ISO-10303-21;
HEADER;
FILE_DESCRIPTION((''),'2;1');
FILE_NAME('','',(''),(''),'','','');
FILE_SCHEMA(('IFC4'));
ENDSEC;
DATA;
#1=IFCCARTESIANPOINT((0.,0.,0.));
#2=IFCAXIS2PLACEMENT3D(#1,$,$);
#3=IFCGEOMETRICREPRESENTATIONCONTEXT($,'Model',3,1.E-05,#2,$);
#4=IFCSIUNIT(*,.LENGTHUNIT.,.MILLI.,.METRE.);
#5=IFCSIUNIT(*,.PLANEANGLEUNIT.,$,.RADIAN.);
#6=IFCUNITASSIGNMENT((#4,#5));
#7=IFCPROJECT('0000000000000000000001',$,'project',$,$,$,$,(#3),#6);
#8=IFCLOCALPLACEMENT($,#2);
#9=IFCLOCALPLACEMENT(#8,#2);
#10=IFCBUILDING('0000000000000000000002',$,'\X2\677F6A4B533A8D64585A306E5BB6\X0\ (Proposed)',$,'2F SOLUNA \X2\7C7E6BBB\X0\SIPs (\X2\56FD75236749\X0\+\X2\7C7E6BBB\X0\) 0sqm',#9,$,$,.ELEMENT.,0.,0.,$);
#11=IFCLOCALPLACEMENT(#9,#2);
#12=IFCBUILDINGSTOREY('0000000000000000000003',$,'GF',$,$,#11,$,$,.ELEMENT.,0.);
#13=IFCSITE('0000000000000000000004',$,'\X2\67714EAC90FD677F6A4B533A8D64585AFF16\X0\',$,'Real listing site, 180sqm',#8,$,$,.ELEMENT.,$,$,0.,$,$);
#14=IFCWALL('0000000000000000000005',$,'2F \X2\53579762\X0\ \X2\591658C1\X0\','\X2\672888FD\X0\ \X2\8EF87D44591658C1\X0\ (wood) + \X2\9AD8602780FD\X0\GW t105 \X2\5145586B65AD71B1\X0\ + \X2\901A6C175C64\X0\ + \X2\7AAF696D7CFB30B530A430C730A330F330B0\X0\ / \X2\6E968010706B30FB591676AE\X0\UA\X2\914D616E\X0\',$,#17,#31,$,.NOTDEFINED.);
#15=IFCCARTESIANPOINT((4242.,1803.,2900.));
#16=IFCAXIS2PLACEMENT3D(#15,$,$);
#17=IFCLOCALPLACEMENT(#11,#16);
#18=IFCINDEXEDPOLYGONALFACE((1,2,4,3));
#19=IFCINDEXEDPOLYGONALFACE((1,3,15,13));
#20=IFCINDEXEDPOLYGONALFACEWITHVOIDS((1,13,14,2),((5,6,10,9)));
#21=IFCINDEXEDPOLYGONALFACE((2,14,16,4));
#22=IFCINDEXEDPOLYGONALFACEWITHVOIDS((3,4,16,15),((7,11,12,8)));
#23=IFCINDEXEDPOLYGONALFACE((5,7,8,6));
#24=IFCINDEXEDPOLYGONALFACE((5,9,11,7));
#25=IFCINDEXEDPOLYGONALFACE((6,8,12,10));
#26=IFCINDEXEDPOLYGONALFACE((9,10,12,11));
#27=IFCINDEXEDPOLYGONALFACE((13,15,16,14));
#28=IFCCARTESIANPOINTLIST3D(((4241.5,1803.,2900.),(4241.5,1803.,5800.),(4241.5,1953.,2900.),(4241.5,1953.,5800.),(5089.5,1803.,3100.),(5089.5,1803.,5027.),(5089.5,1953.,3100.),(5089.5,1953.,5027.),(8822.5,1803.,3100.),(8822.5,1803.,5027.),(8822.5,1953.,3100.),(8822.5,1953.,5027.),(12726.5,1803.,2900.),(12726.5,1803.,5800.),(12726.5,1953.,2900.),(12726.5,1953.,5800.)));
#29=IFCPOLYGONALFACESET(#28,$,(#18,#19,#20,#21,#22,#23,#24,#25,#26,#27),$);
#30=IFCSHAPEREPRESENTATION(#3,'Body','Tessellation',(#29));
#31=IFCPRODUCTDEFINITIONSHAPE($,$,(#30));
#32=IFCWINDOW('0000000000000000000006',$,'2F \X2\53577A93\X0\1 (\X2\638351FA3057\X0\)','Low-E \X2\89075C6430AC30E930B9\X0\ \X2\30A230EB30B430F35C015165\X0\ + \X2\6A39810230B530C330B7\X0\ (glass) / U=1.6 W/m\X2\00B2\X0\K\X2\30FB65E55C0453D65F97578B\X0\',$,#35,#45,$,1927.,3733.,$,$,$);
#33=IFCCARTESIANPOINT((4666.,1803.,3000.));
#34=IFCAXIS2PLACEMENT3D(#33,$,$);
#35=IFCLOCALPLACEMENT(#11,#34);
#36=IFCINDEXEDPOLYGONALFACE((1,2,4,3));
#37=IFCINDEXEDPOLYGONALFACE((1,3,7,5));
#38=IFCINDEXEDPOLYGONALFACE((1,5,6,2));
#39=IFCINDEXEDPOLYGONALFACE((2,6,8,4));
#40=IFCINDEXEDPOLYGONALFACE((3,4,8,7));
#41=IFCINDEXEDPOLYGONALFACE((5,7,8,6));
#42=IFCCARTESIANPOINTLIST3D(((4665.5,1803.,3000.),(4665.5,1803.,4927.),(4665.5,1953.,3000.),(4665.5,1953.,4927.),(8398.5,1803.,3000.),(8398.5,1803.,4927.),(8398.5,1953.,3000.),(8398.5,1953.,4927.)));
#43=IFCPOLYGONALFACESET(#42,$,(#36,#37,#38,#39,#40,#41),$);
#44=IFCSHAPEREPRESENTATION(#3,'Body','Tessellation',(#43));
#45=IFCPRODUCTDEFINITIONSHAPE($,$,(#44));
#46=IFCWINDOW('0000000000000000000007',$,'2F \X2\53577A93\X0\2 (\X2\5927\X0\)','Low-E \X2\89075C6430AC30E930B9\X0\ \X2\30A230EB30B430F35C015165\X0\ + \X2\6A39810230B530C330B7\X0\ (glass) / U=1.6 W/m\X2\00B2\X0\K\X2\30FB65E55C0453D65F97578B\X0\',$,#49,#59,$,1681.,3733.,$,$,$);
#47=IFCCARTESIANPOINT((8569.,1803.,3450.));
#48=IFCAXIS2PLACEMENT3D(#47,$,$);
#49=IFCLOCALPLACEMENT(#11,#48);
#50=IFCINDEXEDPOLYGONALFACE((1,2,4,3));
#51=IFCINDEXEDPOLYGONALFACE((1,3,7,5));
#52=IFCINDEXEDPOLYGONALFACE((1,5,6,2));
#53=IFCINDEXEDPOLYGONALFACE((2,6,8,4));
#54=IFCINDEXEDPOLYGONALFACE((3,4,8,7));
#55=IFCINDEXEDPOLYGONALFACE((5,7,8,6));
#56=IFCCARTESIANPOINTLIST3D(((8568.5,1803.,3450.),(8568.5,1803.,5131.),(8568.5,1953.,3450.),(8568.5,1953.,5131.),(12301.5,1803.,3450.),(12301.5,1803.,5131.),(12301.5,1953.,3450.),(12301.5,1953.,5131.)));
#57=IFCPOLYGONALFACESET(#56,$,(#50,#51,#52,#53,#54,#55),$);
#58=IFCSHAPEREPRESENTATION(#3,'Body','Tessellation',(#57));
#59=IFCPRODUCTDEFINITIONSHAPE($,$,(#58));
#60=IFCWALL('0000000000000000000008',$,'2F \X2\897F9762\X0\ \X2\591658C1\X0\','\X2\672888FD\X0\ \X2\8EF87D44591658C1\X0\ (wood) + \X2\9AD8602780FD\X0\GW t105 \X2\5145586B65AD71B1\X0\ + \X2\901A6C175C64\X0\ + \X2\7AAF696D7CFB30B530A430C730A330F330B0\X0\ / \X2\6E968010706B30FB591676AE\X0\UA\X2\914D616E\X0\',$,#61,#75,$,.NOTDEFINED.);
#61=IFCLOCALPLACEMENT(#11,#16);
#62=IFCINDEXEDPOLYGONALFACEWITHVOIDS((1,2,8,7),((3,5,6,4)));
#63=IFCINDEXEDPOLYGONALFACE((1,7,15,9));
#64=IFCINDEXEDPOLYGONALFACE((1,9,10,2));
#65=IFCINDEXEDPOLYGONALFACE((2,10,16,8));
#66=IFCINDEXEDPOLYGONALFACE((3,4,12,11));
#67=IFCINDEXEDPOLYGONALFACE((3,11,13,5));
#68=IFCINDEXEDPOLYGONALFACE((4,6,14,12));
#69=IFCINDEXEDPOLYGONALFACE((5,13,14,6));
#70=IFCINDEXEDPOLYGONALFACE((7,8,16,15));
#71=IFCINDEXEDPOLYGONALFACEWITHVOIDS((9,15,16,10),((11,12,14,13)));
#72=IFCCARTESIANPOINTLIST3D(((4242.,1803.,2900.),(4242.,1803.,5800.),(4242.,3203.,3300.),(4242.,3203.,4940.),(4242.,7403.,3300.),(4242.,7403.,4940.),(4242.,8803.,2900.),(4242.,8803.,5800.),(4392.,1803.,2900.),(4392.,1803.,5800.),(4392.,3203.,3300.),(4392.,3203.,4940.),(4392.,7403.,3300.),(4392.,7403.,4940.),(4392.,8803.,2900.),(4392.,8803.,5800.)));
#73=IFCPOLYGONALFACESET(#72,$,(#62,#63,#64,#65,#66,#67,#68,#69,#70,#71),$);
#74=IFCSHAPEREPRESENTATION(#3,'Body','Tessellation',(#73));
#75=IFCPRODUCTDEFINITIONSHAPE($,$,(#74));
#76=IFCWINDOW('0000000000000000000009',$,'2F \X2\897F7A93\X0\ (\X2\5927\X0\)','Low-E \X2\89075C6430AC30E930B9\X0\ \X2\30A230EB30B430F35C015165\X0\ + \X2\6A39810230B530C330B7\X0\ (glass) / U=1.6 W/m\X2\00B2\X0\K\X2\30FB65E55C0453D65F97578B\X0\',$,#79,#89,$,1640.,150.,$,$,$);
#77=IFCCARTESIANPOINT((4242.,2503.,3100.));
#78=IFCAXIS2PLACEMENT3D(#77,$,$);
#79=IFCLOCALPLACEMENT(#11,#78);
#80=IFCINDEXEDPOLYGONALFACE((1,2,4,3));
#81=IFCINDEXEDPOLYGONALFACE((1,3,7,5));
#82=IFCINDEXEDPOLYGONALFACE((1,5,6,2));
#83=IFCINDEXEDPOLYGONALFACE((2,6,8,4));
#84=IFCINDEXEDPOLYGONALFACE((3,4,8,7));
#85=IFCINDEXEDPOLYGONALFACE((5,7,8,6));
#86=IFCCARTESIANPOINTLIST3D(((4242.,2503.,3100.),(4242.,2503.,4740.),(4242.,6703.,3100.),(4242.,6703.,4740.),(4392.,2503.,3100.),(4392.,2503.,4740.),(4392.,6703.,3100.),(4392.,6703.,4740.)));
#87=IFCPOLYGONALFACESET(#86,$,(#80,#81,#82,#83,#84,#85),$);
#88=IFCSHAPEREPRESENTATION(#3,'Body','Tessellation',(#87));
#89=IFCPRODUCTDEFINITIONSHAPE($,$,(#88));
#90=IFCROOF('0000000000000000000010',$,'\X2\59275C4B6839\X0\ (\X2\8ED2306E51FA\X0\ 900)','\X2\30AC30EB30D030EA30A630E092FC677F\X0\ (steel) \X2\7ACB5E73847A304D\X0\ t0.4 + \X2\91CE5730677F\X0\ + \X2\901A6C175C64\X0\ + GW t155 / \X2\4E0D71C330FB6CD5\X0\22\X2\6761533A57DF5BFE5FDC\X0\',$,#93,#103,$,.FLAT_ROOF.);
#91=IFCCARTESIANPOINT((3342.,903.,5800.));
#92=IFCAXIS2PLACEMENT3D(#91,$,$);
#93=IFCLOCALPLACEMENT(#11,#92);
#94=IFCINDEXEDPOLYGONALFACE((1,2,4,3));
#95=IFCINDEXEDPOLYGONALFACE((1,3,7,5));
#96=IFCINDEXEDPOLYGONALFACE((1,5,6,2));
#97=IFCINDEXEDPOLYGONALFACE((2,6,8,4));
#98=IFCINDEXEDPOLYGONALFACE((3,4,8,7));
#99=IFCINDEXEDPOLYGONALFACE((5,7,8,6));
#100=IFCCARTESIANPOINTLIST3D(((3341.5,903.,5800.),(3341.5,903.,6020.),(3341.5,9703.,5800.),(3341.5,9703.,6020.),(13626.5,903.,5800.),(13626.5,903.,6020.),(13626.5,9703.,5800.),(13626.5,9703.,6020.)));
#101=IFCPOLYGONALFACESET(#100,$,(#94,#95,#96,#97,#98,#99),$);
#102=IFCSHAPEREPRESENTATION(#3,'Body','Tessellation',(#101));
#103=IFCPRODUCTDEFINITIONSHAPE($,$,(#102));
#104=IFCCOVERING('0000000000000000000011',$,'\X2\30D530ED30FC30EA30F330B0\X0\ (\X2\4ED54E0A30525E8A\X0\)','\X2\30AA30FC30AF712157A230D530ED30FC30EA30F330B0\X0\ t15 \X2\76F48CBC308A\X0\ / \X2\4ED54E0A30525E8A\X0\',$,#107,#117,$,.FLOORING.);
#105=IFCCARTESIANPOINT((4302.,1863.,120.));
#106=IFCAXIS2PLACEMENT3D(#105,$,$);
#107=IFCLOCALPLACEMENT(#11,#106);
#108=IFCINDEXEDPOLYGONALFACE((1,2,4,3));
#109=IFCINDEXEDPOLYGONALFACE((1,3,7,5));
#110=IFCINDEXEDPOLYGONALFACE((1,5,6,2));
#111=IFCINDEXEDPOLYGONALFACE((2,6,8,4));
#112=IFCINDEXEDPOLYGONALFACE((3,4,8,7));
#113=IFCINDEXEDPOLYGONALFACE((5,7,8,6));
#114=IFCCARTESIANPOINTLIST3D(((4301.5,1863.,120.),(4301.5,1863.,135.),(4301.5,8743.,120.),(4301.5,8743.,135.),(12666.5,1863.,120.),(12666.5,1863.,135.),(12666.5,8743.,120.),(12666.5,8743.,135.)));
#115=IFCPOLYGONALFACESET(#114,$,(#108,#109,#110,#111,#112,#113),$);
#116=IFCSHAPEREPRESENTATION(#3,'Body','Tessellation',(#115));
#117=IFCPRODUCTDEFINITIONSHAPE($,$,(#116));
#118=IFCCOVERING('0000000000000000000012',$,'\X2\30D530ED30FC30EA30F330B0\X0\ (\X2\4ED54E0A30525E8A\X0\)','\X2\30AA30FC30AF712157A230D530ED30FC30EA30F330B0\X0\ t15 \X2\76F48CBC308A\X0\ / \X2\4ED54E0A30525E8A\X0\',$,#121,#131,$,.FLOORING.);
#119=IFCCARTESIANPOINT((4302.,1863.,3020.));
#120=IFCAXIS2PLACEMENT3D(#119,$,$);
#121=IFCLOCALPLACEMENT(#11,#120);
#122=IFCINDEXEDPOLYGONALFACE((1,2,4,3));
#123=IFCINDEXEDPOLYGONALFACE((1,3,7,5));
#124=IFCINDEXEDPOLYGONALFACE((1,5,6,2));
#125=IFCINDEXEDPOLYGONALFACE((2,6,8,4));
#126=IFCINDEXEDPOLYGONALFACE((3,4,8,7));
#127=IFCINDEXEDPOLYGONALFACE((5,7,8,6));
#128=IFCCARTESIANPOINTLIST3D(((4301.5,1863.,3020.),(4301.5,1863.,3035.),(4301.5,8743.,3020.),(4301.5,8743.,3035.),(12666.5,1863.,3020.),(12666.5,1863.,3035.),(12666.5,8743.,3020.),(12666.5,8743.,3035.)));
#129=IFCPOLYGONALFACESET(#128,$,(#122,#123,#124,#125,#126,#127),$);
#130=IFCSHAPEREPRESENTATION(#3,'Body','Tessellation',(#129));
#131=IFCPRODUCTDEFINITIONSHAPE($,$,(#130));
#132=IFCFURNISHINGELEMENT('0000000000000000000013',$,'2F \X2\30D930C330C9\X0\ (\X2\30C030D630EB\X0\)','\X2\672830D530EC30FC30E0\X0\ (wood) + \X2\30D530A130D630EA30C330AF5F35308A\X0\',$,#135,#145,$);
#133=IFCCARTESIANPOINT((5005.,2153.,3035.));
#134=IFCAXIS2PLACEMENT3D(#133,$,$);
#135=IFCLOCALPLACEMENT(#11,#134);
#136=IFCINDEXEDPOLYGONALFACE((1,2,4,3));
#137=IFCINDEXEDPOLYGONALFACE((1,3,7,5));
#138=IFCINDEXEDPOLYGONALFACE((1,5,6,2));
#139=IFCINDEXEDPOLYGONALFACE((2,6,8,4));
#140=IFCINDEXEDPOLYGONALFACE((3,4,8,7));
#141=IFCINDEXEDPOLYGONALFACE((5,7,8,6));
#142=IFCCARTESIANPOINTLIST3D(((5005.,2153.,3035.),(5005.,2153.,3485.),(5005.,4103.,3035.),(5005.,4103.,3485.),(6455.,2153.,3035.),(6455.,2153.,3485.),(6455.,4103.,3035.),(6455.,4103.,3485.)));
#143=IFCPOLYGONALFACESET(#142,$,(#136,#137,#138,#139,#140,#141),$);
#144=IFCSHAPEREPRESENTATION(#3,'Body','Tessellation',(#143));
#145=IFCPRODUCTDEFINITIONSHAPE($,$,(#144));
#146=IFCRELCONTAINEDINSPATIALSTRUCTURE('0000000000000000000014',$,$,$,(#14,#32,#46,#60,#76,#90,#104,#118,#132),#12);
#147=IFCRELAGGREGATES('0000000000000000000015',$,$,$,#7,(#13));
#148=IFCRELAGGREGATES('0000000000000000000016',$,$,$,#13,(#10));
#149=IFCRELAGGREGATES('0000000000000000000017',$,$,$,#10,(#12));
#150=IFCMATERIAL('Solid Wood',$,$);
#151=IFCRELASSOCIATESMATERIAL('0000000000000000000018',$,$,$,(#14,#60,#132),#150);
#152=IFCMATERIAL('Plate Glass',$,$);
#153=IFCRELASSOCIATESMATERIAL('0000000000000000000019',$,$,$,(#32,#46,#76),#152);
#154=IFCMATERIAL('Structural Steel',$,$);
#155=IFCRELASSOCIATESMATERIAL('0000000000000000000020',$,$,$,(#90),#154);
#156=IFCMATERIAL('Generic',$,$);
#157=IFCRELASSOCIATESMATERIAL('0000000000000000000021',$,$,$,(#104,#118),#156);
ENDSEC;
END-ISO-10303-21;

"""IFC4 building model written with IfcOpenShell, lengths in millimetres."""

from ifc_helpers import new_model, si_unit, frame, frame_2d, origin, place, context, project, spatial, rectangle, extrude, material, element, fill, save


model = new_model("IFC4")

# Units and contexts
model_context = context("Model", 3, precision=1e-05, world=origin())
ifc_project = project(units=[si_unit("LENGTHUNIT", "METRE", prefix="MILLI"), si_unit("PLANEANGLEUNIT", "RADIAN")], contexts=[model_context])

# Site, building, storey
site_placement = place(None, origin())
site = spatial("IfcSite", under=ifc_project, at=site_placement, Name="東京都板橋区赤塚６", ObjectType="Real listing site, 180sqm", CompositionType="ELEMENT", RefElevation=0.0)
building_placement = place(site_placement, origin())
building = spatial("IfcBuilding", under=site, at=building_placement, Name="板橋区赤塚の家 (Proposed)", ObjectType="2F SOLUNA 籾殻SIPs (国産杉+籾殻) 0sqm", CompositionType="ELEMENT", ElevationOfRefHeight=0.0, ElevationOfTerrain=0.0)
storey_placement = place(building_placement, origin())
storey = spatial("IfcBuildingStorey", under=building, at=storey_placement, Name="GF", CompositionType="ELEMENT", Elevation=0.0)

# Shared definitions
ifc_material_1 = material(Name="Solid Wood")

# Shared definitions
ifc_material_2 = material(Name="Plate Glass")

# Wall, openings, windows
wall_1_placement = place(storey_placement, frame((4242.0, 1803.0, 2900.0)))
wall_1 = element("IfcWall", 1, at=wall_1_placement, inside=storey, material=ifc_material_1, Name="2F 南面 外壁", Description="木製 軸組外壁 (wood) + 高性能GW t105 充填断熱 + 通気層 + 窯業系サイディング / 準耐火・外皮UA配慮", PredefinedType="NOTDEFINED", context=model_context, shape_type="SweptSolid", body=[
    extrude(rectangle(XDim=8485.0, YDim=150.0, at=frame_2d((4242.0, 75.0))), frame((4242.0, 1803.0, 2900.0)), (0.0, 0.0, 1.0), 2900.0),
])
opening_1_placement = place(storey_placement, frame((4666.0, 1803.0, 3000.0)))
opening_1 = element("IfcOpeningElement", 2, at=opening_1_placement, cuts=wall_1, PredefinedType="NOTDEFINED", context=model_context, shape_type="SweptSolid", body=[
    extrude(rectangle(XDim=3733.0, YDim=150.0, at=frame_2d((1866.0, 75.0))), frame((4666.0, 1803.0, 3000.0)), (0.0, 0.0, 1.0), 1927.0),
])
opening_2_placement = place(storey_placement, frame((8569.0, 1803.0, 3450.0)))
opening_2 = element("IfcOpeningElement", 3, at=opening_2_placement, cuts=wall_1, PredefinedType="NOTDEFINED", context=model_context, shape_type="SweptSolid", body=[
    extrude(rectangle(XDim=3733.0, YDim=150.0, at=frame_2d((1866.0, 75.0))), frame((8569.0, 1803.0, 3450.0)), (0.0, 0.0, 1.0), 1681.0),
])
window_1_placement = place(storey_placement, frame((4666.0, 1803.0, 3000.0)))
window_1 = element("IfcWindow", 4, at=window_1_placement, inside=storey, material=ifc_material_2, Name="2F 南窓1 (掃出し)", Description="Low-E 複層ガラス アルゴン封入 + 樹脂サッシ (glass) / U=1.6 W/m²K・日射取得型", OverallHeight=1927.0, OverallWidth=3733.0, context=model_context, shape_type="SweptSolid", body=[
    extrude(rectangle(XDim=3733.0, YDim=150.0, at=frame_2d((1866.0, 75.0))), frame((4666.0, 1803.0, 3000.0)), (0.0, 0.0, 1.0), 1927.0),
])
fill(opening_1, window_1)
window_2_placement = place(storey_placement, frame((8569.0, 1803.0, 3450.0)))
window_2 = element("IfcWindow", 5, at=window_2_placement, inside=storey, material=ifc_material_2, Name="2F 南窓2 (大)", Description="Low-E 複層ガラス アルゴン封入 + 樹脂サッシ (glass) / U=1.6 W/m²K・日射取得型", OverallHeight=1681.0, OverallWidth=3733.0, context=model_context, shape_type="SweptSolid", body=[
    extrude(rectangle(XDim=3733.0, YDim=150.0, at=frame_2d((1866.0, 75.0))), frame((8569.0, 1803.0, 3450.0)), (0.0, 0.0, 1.0), 1681.0),
])
fill(opening_2, window_2)

# Wall, opening, window
wall_2_placement = place(storey_placement, frame((4242.0, 1803.0, 2900.0)))
wall_2 = element("IfcWall", 6, at=wall_2_placement, inside=storey, material=ifc_material_1, Name="2F 西面 外壁", Description="木製 軸組外壁 (wood) + 高性能GW t105 充填断熱 + 通気層 + 窯業系サイディング / 準耐火・外皮UA配慮", PredefinedType="NOTDEFINED", context=model_context, shape_type="SweptSolid", body=[
    extrude(rectangle(XDim=150.0, YDim=7000.0, at=frame_2d((75.0, 3500.0))), frame((4242.0, 1803.0, 2900.0)), (0.0, 0.0, 1.0), 2900.0),
])
opening_3_placement = place(storey_placement, frame((4242.0, 2503.0, 3100.0)))
opening_3 = element("IfcOpeningElement", 7, at=opening_3_placement, cuts=wall_2, PredefinedType="NOTDEFINED", context=model_context, shape_type="SweptSolid", body=[
    extrude(rectangle(XDim=150.0, YDim=4200.0, at=frame_2d((75.0, 2100.0))), frame((4242.0, 2503.0, 3100.0)), (0.0, 0.0, 1.0), 1640.0),
])
window_3_placement = place(storey_placement, frame((4242.0, 2503.0, 3100.0)))
window_3 = element("IfcWindow", 8, at=window_3_placement, inside=storey, material=ifc_material_2, Name="2F 西窓 (大)", Description="Low-E 複層ガラス アルゴン封入 + 樹脂サッシ (glass) / U=1.6 W/m²K・日射取得型", OverallHeight=1640.0, OverallWidth=150.0, context=model_context, shape_type="SweptSolid", body=[
    extrude(rectangle(XDim=150.0, YDim=4200.0, at=frame_2d((75.0, 2100.0))), frame((4242.0, 2503.0, 3100.0)), (0.0, 0.0, 1.0), 1640.0),
])
fill(opening_3, window_3)

# Roof
ifc_material_3 = material(Name="Structural Steel")
roof_placement = place(storey_placement, frame((3342.0, 903.0, 5800.0)))
element("IfcRoof", 9, at=roof_placement, inside=storey, material=ifc_material_3, Name="大屋根 (軒の出 900)", Description="ガルバリウム鋼板 (steel) 立平葺き t0.4 + 野地板 + 通気層 + GW t155 / 不燃・法22条区域対応", PredefinedType="FLAT_ROOF", context=model_context, shape_type="SweptSolid", body=[
    extrude(rectangle(XDim=10285.0, YDim=8800.0, at=frame_2d((5142.0, 4400.0))), frame((3342.0, 903.0, 5800.0)), (0.0, 0.0, 1.0), 220.0),
])

# Coverings
ifc_material_4 = material(Name="Generic")
covering_1_placement = place(storey_placement, frame((4302.0, 1863.0, 120.0)))
element("IfcCovering", 10, at=covering_1_placement, inside=storey, material=ifc_material_4, Name="フローリング (仕上げ床)", Description="オーク無垢フローリング t15 直貼り / 仕上げ床", PredefinedType="FLOORING", context=model_context, shape_type="SweptSolid", body=[
    extrude(rectangle(XDim=8365.0, YDim=6880.0, at=frame_2d((4182.0, 3440.0))), frame((4302.0, 1863.0, 120.0)), (0.0, 0.0, 1.0), 15.0),
])
covering_2_placement = place(storey_placement, frame((4302.0, 1863.0, 3020.0)))
element("IfcCovering", 11, at=covering_2_placement, inside=storey, material=ifc_material_4, Name="フローリング (仕上げ床)", Description="オーク無垢フローリング t15 直貼り / 仕上げ床", PredefinedType="FLOORING", context=model_context, shape_type="SweptSolid", body=[
    extrude(rectangle(XDim=8365.0, YDim=6880.0, at=frame_2d((4182.0, 3440.0))), frame((4302.0, 1863.0, 3020.0)), (0.0, 0.0, 1.0), 15.0),
])

# Furnishing element
furnishing_placement = place(storey_placement, frame((5005.0, 2153.0, 3035.0)))
element("IfcFurnishingElement", 12, at=furnishing_placement, inside=storey, material=ifc_material_1, Name="2F ベッド (ダブル)", Description="木フレーム (wood) + ファブリック張り", context=model_context, shape_type="SweptSolid", body=[
    extrude(rectangle(XDim=1450.0, YDim=1950.0, at=frame_2d((725.0, 975.0))), frame((5005.0, 2153.0, 3035.0)), (0.0, 0.0, 1.0), 450.0),
])

save(model, "model.ifc")
